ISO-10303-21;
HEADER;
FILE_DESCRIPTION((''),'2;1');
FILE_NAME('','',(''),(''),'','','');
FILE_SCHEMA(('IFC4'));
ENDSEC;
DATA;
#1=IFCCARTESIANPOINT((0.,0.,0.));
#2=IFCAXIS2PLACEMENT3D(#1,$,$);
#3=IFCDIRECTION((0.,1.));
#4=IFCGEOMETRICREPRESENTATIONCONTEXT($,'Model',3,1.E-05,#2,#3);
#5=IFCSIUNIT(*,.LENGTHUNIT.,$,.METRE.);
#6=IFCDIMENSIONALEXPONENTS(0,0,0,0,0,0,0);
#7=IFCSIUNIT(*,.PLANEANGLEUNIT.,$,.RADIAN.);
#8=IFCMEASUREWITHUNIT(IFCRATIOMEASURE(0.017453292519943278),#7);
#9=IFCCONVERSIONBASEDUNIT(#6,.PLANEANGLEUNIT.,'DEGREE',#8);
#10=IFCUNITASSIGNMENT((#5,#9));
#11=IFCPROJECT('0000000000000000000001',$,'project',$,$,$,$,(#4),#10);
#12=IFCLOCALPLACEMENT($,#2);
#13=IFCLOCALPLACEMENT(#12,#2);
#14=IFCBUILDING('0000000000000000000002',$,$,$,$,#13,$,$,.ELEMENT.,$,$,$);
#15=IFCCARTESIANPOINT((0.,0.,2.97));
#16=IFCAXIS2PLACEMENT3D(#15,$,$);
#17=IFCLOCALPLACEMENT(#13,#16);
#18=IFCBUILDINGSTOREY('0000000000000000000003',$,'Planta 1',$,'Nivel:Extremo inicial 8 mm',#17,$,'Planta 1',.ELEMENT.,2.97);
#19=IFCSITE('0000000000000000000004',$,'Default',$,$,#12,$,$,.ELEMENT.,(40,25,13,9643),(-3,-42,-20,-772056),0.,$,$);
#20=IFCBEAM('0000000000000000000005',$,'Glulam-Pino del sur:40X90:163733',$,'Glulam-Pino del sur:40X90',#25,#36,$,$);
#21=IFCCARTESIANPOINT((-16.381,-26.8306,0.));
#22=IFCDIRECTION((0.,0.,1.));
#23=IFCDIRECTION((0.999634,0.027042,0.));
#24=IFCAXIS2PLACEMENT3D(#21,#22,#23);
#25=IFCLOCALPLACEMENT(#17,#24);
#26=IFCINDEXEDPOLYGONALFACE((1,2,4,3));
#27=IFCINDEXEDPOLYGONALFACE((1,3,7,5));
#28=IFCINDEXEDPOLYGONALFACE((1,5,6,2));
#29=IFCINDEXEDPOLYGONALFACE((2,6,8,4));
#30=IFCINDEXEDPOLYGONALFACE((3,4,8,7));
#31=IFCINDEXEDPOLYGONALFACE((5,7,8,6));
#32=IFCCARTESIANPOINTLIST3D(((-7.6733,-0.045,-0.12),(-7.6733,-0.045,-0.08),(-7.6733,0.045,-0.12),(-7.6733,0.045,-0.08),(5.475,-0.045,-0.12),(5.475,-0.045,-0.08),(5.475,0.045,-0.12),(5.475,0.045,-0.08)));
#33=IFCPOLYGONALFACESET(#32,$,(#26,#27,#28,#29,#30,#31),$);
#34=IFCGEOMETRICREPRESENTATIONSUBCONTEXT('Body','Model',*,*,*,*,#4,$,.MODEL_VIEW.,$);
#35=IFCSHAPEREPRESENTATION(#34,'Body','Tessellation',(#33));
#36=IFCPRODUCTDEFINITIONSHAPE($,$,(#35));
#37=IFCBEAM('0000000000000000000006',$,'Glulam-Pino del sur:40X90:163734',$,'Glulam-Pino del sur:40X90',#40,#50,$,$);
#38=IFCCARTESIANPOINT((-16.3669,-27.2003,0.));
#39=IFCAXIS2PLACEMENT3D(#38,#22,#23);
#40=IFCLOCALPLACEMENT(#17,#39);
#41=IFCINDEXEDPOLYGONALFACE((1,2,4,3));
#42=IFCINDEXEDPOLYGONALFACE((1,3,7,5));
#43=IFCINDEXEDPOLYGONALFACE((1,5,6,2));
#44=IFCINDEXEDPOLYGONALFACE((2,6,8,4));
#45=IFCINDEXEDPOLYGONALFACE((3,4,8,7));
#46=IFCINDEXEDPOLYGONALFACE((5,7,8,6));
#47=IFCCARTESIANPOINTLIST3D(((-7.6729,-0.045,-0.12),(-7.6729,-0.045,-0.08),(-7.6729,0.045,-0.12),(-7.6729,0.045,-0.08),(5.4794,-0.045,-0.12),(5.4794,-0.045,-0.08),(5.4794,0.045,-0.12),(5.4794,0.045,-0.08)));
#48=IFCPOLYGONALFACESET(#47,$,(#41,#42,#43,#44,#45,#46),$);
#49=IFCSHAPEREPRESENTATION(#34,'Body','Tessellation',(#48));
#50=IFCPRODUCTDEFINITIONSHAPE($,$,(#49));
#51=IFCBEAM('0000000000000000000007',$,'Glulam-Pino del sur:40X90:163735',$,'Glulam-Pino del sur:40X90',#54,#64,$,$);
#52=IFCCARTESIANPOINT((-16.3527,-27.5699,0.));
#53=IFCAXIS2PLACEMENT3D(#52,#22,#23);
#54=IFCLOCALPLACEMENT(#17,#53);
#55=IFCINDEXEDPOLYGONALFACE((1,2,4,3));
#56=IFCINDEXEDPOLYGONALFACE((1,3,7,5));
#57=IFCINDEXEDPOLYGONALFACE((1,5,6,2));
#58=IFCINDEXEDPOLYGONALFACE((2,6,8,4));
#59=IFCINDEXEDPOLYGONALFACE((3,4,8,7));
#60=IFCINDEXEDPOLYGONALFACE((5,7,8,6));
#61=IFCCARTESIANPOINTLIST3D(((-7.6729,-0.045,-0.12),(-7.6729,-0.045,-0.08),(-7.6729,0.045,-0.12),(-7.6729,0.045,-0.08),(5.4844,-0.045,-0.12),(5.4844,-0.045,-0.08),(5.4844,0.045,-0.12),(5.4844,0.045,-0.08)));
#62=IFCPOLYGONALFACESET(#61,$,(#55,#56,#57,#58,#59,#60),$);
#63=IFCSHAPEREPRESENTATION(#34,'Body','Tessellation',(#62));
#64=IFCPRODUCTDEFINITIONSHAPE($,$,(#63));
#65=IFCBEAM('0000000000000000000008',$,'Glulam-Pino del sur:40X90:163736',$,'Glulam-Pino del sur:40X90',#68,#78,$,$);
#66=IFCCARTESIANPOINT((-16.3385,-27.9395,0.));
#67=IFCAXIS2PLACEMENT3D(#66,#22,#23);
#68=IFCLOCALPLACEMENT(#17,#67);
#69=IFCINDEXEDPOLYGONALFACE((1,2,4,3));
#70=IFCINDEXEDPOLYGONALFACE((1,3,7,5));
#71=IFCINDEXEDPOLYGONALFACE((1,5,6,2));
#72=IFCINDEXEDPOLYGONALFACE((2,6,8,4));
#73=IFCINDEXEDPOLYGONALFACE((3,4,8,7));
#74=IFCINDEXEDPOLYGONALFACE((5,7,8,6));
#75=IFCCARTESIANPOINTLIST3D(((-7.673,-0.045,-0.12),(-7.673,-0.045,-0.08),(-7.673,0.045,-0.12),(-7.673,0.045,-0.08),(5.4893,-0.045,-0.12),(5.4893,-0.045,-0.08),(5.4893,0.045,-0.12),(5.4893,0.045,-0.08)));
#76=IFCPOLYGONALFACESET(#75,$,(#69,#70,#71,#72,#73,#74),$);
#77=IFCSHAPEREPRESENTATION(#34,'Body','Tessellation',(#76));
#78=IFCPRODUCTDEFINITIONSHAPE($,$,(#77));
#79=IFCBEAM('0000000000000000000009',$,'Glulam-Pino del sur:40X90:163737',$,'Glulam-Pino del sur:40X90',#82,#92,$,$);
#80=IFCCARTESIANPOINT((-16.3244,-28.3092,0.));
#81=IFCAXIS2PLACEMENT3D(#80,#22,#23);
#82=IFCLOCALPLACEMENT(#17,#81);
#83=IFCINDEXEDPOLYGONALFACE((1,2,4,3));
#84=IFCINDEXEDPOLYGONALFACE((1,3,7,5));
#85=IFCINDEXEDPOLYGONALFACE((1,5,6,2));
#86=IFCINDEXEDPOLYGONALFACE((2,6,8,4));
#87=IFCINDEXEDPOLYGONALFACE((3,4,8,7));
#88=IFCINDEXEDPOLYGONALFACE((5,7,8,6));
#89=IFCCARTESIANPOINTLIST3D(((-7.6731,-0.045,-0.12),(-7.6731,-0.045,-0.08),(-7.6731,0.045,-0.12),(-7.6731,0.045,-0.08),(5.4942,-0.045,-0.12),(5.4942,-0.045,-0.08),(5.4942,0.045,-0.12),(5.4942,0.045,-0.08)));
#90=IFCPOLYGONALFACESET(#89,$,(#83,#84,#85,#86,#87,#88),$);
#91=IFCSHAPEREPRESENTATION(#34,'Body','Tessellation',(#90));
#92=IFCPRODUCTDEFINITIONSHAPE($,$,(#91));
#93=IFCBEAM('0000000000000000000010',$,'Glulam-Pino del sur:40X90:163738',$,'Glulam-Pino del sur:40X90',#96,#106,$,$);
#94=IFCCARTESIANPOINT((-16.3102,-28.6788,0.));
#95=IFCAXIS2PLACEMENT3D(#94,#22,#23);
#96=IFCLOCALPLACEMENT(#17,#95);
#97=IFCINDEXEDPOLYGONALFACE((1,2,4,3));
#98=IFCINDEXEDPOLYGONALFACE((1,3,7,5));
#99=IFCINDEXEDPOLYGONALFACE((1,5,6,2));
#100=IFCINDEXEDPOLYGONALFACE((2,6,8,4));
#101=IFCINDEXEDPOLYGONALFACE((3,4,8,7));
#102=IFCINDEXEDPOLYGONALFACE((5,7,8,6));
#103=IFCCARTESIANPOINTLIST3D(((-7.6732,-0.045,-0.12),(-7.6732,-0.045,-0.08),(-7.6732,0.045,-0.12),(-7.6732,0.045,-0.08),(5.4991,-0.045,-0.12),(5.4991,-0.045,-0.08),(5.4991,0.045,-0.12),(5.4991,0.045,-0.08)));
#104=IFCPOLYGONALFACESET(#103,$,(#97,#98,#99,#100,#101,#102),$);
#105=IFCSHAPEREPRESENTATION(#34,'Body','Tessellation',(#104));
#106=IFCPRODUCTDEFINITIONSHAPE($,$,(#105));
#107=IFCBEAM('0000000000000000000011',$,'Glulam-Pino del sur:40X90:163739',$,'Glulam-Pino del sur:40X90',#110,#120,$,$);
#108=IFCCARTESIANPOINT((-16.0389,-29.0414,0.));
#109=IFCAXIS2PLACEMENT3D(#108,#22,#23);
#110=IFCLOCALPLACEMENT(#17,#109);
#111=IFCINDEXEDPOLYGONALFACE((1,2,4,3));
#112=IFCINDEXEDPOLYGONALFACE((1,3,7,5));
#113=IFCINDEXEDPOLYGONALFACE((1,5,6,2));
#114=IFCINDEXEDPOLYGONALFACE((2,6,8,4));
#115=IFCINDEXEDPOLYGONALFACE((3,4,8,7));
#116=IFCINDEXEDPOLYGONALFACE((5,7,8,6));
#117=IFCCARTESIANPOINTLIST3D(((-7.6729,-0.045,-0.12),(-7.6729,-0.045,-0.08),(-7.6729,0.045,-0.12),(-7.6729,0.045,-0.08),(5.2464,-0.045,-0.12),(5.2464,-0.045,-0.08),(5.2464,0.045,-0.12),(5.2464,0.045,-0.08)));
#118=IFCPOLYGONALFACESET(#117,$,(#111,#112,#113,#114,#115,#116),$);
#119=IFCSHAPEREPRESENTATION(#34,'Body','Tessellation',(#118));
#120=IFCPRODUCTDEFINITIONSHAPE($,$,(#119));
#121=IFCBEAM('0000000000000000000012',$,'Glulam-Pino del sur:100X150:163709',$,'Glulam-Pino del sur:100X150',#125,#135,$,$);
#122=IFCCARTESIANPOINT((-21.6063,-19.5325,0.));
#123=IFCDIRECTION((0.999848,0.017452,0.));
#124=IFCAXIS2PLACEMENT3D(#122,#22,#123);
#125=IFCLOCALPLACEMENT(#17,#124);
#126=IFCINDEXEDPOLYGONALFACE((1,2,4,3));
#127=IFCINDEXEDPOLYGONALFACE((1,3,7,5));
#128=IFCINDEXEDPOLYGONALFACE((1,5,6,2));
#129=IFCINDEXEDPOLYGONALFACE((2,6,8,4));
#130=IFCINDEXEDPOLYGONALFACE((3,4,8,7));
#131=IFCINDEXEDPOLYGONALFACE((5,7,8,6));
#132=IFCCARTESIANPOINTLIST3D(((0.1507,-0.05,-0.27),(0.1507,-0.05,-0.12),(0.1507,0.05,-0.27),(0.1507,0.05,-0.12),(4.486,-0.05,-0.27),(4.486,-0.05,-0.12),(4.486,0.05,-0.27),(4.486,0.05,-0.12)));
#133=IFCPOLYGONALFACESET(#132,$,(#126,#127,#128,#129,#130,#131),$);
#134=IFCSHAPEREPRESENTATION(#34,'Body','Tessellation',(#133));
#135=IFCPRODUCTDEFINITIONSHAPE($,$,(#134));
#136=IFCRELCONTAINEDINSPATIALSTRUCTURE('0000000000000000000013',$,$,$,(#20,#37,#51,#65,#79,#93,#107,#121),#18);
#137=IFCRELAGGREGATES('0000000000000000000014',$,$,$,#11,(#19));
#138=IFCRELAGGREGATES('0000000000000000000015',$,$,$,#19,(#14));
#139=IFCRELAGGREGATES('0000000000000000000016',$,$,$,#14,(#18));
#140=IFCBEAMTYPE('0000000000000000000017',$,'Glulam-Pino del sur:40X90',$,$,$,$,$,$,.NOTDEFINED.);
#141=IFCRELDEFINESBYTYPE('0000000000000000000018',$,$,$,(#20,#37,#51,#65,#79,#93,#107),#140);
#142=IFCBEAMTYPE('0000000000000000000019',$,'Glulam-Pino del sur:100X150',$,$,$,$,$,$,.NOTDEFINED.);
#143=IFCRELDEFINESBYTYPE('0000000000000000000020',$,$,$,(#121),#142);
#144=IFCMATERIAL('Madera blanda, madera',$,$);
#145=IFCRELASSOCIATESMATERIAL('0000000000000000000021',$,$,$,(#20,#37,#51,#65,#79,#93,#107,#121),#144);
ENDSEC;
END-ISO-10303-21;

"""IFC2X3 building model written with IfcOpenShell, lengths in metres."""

from ifc_helpers import new_model, entity, si_unit, converted_unit, direction, frame, frame_2d, origin, origin_2d_with_axis, place, context, subcontext, project, spatial, rectangle, extrude, material, type_object, element, save


model = new_model("IFC2X3")

# Units and contexts
model_context = context("Model", 3, precision=1e-05, world=origin(), true_north=direction((0.0, 1.0)))
body_context = subcontext(model_context, "Body", "Model", "MODEL_VIEW")
ifc_project = project(units=[si_unit("LENGTHUNIT", "METRE"), converted_unit("PLANEANGLEUNIT", "DEGREE", entity("IfcRatioMeasure", 0.017453292519943278), si_unit("PLANEANGLEUNIT", "RADIAN"), dimensions=[0, 0, 0, 0, 0, 0, 0])], contexts=[model_context])

# Site, building, storey
site_placement = place(None, origin())
site = spatial("IfcSite", under=ifc_project, at=site_placement, Name="Default", CompositionType="ELEMENT", RefLatitude=(40, 25, 13, 9643), RefLongitude=(-3, -42, -20, -772056), RefElevation=0.0)
building_placement = place(site_placement, origin())
building = spatial("IfcBuilding", under=site, at=building_placement, CompositionType="ELEMENT")
storey_placement = place(building_placement, frame((0.0, 0.0, 2.97)))
storey = spatial("IfcBuildingStorey", under=building, at=storey_placement, Name="Planta 1", ObjectType="Nivel:Extremo inicial 8 mm", LongName="Planta 1", CompositionType="ELEMENT", Elevation=2.97)

# Beams
ifc_material_1 = material(Name="Madera blanda, madera")
beam_type_1 = type_object("IfcBeamType", Name="Glulam-Pino del sur:40X90", PredefinedType="NOTDEFINED")
beam_1_placement = place(storey_placement, frame((-16.381, -26.8306, 0.0), z_axis=(0.0, 0.0, 1.0), x_axis=(0.999634, 0.027042, 0.0)))
element("IfcBeam", 1, at=beam_1_placement, inside=storey, type_object=beam_type_1, material=ifc_material_1, Name="Glulam-Pino del sur:40X90:163733", ObjectType="Glulam-Pino del sur:40X90", context=body_context, shape_type="SweptSolid", body=[
    extrude(rectangle(XDim=0.04, YDim=0.09, at=origin_2d_with_axis()), frame((-7.6733, 0.0, -0.1), z_axis=(1.0, 0.0, 0.0), x_axis=(0.0, 0.0, -1.0)), (0.0, 0.0, 1.0), 13.1483),
])
beam_2_placement = place(storey_placement, frame((-16.3669, -27.2003, 0.0), z_axis=(0.0, 0.0, 1.0), x_axis=(0.999634, 0.027042, 0.0)))
element("IfcBeam", 2, at=beam_2_placement, inside=storey, type_object=beam_type_1, material=ifc_material_1, Name="Glulam-Pino del sur:40X90:163734", ObjectType="Glulam-Pino del sur:40X90", context=body_context, shape_type="SweptSolid", body=[
    extrude(rectangle(XDim=0.04, YDim=0.09, at=origin_2d_with_axis()), frame((-7.6729, 0.0, -0.1), z_axis=(1.0, 0.0, 0.0), x_axis=(0.0, 0.0, -1.0)), (0.0, 0.0, 1.0), 13.1523),
])
beam_3_placement = place(storey_placement, frame((-16.3527, -27.5699, 0.0), z_axis=(0.0, 0.0, 1.0), x_axis=(0.999634, 0.027042, 0.0)))
element("IfcBeam", 3, at=beam_3_placement, inside=storey, type_object=beam_type_1, material=ifc_material_1, Name="Glulam-Pino del sur:40X90:163735", ObjectType="Glulam-Pino del sur:40X90", context=body_context, shape_type="SweptSolid", body=[
    extrude(rectangle(XDim=0.04, YDim=0.09, at=origin_2d_with_axis()), frame((-7.6729, 0.0, -0.1), z_axis=(1.0, 0.0, 0.0), x_axis=(0.0, 0.0, -1.0)), (0.0, 0.0, 1.0), 13.1573),
])
beam_4_placement = place(storey_placement, frame((-16.3385, -27.9395, 0.0), z_axis=(0.0, 0.0, 1.0), x_axis=(0.999634, 0.027042, 0.0)))
element("IfcBeam", 4, at=beam_4_placement, inside=storey, type_object=beam_type_1, material=ifc_material_1, Name="Glulam-Pino del sur:40X90:163736", ObjectType="Glulam-Pino del sur:40X90", context=body_context, shape_type="SweptSolid", body=[
    extrude(rectangle(XDim=0.04, YDim=0.09, at=origin_2d_with_axis()), frame((-7.673, 0.0, -0.1), z_axis=(1.0, 0.0, 0.0), x_axis=(0.0, 0.0, -1.0)), (0.0, 0.0, 1.0), 13.1623),
])
beam_5_placement = place(storey_placement, frame((-16.3244, -28.3092, 0.0), z_axis=(0.0, 0.0, 1.0), x_axis=(0.999634, 0.027042, 0.0)))
element("IfcBeam", 5, at=beam_5_placement, inside=storey, type_object=beam_type_1, material=ifc_material_1, Name="Glulam-Pino del sur:40X90:163737", ObjectType="Glulam-Pino del sur:40X90", context=body_context, shape_type="SweptSolid", body=[
    extrude(rectangle(XDim=0.04, YDim=0.09, at=origin_2d_with_axis()), frame((-7.6731, 0.0, -0.1), z_axis=(1.0, 0.0, 0.0), x_axis=(0.0, 0.0, -1.0)), (0.0, 0.0, 1.0), 13.1673),
])
beam_6_placement = place(storey_placement, frame((-16.3102, -28.6788, 0.0), z_axis=(0.0, 0.0, 1.0), x_axis=(0.999634, 0.027042, 0.0)))
element("IfcBeam", 6, at=beam_6_placement, inside=storey, type_object=beam_type_1, material=ifc_material_1, Name="Glulam-Pino del sur:40X90:163738", ObjectType="Glulam-Pino del sur:40X90", context=body_context, shape_type="SweptSolid", body=[
    extrude(rectangle(XDim=0.04, YDim=0.09, at=frame_2d((0.0, 0.0), x_axis=(1.0, 0.0))), frame((-7.6732, 0.0, -0.1), z_axis=(1.0, 0.0, 0.0), x_axis=(0.0, 0.0, -1.0)), (0.0, 0.0, 1.0), 13.1723),
])
beam_7_placement = place(storey_placement, frame((-16.0389, -29.0414, 0.0), z_axis=(0.0, 0.0, 1.0), x_axis=(0.999634, 0.027042, 0.0)))
element("IfcBeam", 7, at=beam_7_placement, inside=storey, type_object=beam_type_1, material=ifc_material_1, Name="Glulam-Pino del sur:40X90:163739", ObjectType="Glulam-Pino del sur:40X90", context=body_context, shape_type="SweptSolid", body=[
    extrude(rectangle(XDim=0.04, YDim=0.09, at=origin_2d_with_axis()), frame((-7.6729, 0.0, -0.1), z_axis=(1.0, 0.0, 0.0), x_axis=(0.0, 0.0, -1.0)), (0.0, 0.0, 1.0), 12.9193),
])
beam_type_2 = type_object("IfcBeamType", Name="Glulam-Pino del sur:100X150", PredefinedType="NOTDEFINED")
beam_8_placement = place(storey_placement, frame((-21.6063, -19.5325, 0.0), z_axis=(0.0, 0.0, 1.0), x_axis=(0.999848, 0.017452, 0.0)))
element("IfcBeam", 8, at=beam_8_placement, inside=storey, type_object=beam_type_2, material=ifc_material_1, Name="Glulam-Pino del sur:100X150:163709", ObjectType="Glulam-Pino del sur:100X150", context=body_context, shape_type="SweptSolid", body=[
    extrude(rectangle(XDim=0.15, YDim=0.1, at=frame_2d((0.0, 0.0), x_axis=(1.0, 0.0))), frame((0.1507, 0.0, -0.195), z_axis=(1.0, 0.0, 0.0), x_axis=(0.0, 0.0, -1.0)), (0.0, 0.0, 1.0), 4.3353),
])

save(model, "model.ifc")
